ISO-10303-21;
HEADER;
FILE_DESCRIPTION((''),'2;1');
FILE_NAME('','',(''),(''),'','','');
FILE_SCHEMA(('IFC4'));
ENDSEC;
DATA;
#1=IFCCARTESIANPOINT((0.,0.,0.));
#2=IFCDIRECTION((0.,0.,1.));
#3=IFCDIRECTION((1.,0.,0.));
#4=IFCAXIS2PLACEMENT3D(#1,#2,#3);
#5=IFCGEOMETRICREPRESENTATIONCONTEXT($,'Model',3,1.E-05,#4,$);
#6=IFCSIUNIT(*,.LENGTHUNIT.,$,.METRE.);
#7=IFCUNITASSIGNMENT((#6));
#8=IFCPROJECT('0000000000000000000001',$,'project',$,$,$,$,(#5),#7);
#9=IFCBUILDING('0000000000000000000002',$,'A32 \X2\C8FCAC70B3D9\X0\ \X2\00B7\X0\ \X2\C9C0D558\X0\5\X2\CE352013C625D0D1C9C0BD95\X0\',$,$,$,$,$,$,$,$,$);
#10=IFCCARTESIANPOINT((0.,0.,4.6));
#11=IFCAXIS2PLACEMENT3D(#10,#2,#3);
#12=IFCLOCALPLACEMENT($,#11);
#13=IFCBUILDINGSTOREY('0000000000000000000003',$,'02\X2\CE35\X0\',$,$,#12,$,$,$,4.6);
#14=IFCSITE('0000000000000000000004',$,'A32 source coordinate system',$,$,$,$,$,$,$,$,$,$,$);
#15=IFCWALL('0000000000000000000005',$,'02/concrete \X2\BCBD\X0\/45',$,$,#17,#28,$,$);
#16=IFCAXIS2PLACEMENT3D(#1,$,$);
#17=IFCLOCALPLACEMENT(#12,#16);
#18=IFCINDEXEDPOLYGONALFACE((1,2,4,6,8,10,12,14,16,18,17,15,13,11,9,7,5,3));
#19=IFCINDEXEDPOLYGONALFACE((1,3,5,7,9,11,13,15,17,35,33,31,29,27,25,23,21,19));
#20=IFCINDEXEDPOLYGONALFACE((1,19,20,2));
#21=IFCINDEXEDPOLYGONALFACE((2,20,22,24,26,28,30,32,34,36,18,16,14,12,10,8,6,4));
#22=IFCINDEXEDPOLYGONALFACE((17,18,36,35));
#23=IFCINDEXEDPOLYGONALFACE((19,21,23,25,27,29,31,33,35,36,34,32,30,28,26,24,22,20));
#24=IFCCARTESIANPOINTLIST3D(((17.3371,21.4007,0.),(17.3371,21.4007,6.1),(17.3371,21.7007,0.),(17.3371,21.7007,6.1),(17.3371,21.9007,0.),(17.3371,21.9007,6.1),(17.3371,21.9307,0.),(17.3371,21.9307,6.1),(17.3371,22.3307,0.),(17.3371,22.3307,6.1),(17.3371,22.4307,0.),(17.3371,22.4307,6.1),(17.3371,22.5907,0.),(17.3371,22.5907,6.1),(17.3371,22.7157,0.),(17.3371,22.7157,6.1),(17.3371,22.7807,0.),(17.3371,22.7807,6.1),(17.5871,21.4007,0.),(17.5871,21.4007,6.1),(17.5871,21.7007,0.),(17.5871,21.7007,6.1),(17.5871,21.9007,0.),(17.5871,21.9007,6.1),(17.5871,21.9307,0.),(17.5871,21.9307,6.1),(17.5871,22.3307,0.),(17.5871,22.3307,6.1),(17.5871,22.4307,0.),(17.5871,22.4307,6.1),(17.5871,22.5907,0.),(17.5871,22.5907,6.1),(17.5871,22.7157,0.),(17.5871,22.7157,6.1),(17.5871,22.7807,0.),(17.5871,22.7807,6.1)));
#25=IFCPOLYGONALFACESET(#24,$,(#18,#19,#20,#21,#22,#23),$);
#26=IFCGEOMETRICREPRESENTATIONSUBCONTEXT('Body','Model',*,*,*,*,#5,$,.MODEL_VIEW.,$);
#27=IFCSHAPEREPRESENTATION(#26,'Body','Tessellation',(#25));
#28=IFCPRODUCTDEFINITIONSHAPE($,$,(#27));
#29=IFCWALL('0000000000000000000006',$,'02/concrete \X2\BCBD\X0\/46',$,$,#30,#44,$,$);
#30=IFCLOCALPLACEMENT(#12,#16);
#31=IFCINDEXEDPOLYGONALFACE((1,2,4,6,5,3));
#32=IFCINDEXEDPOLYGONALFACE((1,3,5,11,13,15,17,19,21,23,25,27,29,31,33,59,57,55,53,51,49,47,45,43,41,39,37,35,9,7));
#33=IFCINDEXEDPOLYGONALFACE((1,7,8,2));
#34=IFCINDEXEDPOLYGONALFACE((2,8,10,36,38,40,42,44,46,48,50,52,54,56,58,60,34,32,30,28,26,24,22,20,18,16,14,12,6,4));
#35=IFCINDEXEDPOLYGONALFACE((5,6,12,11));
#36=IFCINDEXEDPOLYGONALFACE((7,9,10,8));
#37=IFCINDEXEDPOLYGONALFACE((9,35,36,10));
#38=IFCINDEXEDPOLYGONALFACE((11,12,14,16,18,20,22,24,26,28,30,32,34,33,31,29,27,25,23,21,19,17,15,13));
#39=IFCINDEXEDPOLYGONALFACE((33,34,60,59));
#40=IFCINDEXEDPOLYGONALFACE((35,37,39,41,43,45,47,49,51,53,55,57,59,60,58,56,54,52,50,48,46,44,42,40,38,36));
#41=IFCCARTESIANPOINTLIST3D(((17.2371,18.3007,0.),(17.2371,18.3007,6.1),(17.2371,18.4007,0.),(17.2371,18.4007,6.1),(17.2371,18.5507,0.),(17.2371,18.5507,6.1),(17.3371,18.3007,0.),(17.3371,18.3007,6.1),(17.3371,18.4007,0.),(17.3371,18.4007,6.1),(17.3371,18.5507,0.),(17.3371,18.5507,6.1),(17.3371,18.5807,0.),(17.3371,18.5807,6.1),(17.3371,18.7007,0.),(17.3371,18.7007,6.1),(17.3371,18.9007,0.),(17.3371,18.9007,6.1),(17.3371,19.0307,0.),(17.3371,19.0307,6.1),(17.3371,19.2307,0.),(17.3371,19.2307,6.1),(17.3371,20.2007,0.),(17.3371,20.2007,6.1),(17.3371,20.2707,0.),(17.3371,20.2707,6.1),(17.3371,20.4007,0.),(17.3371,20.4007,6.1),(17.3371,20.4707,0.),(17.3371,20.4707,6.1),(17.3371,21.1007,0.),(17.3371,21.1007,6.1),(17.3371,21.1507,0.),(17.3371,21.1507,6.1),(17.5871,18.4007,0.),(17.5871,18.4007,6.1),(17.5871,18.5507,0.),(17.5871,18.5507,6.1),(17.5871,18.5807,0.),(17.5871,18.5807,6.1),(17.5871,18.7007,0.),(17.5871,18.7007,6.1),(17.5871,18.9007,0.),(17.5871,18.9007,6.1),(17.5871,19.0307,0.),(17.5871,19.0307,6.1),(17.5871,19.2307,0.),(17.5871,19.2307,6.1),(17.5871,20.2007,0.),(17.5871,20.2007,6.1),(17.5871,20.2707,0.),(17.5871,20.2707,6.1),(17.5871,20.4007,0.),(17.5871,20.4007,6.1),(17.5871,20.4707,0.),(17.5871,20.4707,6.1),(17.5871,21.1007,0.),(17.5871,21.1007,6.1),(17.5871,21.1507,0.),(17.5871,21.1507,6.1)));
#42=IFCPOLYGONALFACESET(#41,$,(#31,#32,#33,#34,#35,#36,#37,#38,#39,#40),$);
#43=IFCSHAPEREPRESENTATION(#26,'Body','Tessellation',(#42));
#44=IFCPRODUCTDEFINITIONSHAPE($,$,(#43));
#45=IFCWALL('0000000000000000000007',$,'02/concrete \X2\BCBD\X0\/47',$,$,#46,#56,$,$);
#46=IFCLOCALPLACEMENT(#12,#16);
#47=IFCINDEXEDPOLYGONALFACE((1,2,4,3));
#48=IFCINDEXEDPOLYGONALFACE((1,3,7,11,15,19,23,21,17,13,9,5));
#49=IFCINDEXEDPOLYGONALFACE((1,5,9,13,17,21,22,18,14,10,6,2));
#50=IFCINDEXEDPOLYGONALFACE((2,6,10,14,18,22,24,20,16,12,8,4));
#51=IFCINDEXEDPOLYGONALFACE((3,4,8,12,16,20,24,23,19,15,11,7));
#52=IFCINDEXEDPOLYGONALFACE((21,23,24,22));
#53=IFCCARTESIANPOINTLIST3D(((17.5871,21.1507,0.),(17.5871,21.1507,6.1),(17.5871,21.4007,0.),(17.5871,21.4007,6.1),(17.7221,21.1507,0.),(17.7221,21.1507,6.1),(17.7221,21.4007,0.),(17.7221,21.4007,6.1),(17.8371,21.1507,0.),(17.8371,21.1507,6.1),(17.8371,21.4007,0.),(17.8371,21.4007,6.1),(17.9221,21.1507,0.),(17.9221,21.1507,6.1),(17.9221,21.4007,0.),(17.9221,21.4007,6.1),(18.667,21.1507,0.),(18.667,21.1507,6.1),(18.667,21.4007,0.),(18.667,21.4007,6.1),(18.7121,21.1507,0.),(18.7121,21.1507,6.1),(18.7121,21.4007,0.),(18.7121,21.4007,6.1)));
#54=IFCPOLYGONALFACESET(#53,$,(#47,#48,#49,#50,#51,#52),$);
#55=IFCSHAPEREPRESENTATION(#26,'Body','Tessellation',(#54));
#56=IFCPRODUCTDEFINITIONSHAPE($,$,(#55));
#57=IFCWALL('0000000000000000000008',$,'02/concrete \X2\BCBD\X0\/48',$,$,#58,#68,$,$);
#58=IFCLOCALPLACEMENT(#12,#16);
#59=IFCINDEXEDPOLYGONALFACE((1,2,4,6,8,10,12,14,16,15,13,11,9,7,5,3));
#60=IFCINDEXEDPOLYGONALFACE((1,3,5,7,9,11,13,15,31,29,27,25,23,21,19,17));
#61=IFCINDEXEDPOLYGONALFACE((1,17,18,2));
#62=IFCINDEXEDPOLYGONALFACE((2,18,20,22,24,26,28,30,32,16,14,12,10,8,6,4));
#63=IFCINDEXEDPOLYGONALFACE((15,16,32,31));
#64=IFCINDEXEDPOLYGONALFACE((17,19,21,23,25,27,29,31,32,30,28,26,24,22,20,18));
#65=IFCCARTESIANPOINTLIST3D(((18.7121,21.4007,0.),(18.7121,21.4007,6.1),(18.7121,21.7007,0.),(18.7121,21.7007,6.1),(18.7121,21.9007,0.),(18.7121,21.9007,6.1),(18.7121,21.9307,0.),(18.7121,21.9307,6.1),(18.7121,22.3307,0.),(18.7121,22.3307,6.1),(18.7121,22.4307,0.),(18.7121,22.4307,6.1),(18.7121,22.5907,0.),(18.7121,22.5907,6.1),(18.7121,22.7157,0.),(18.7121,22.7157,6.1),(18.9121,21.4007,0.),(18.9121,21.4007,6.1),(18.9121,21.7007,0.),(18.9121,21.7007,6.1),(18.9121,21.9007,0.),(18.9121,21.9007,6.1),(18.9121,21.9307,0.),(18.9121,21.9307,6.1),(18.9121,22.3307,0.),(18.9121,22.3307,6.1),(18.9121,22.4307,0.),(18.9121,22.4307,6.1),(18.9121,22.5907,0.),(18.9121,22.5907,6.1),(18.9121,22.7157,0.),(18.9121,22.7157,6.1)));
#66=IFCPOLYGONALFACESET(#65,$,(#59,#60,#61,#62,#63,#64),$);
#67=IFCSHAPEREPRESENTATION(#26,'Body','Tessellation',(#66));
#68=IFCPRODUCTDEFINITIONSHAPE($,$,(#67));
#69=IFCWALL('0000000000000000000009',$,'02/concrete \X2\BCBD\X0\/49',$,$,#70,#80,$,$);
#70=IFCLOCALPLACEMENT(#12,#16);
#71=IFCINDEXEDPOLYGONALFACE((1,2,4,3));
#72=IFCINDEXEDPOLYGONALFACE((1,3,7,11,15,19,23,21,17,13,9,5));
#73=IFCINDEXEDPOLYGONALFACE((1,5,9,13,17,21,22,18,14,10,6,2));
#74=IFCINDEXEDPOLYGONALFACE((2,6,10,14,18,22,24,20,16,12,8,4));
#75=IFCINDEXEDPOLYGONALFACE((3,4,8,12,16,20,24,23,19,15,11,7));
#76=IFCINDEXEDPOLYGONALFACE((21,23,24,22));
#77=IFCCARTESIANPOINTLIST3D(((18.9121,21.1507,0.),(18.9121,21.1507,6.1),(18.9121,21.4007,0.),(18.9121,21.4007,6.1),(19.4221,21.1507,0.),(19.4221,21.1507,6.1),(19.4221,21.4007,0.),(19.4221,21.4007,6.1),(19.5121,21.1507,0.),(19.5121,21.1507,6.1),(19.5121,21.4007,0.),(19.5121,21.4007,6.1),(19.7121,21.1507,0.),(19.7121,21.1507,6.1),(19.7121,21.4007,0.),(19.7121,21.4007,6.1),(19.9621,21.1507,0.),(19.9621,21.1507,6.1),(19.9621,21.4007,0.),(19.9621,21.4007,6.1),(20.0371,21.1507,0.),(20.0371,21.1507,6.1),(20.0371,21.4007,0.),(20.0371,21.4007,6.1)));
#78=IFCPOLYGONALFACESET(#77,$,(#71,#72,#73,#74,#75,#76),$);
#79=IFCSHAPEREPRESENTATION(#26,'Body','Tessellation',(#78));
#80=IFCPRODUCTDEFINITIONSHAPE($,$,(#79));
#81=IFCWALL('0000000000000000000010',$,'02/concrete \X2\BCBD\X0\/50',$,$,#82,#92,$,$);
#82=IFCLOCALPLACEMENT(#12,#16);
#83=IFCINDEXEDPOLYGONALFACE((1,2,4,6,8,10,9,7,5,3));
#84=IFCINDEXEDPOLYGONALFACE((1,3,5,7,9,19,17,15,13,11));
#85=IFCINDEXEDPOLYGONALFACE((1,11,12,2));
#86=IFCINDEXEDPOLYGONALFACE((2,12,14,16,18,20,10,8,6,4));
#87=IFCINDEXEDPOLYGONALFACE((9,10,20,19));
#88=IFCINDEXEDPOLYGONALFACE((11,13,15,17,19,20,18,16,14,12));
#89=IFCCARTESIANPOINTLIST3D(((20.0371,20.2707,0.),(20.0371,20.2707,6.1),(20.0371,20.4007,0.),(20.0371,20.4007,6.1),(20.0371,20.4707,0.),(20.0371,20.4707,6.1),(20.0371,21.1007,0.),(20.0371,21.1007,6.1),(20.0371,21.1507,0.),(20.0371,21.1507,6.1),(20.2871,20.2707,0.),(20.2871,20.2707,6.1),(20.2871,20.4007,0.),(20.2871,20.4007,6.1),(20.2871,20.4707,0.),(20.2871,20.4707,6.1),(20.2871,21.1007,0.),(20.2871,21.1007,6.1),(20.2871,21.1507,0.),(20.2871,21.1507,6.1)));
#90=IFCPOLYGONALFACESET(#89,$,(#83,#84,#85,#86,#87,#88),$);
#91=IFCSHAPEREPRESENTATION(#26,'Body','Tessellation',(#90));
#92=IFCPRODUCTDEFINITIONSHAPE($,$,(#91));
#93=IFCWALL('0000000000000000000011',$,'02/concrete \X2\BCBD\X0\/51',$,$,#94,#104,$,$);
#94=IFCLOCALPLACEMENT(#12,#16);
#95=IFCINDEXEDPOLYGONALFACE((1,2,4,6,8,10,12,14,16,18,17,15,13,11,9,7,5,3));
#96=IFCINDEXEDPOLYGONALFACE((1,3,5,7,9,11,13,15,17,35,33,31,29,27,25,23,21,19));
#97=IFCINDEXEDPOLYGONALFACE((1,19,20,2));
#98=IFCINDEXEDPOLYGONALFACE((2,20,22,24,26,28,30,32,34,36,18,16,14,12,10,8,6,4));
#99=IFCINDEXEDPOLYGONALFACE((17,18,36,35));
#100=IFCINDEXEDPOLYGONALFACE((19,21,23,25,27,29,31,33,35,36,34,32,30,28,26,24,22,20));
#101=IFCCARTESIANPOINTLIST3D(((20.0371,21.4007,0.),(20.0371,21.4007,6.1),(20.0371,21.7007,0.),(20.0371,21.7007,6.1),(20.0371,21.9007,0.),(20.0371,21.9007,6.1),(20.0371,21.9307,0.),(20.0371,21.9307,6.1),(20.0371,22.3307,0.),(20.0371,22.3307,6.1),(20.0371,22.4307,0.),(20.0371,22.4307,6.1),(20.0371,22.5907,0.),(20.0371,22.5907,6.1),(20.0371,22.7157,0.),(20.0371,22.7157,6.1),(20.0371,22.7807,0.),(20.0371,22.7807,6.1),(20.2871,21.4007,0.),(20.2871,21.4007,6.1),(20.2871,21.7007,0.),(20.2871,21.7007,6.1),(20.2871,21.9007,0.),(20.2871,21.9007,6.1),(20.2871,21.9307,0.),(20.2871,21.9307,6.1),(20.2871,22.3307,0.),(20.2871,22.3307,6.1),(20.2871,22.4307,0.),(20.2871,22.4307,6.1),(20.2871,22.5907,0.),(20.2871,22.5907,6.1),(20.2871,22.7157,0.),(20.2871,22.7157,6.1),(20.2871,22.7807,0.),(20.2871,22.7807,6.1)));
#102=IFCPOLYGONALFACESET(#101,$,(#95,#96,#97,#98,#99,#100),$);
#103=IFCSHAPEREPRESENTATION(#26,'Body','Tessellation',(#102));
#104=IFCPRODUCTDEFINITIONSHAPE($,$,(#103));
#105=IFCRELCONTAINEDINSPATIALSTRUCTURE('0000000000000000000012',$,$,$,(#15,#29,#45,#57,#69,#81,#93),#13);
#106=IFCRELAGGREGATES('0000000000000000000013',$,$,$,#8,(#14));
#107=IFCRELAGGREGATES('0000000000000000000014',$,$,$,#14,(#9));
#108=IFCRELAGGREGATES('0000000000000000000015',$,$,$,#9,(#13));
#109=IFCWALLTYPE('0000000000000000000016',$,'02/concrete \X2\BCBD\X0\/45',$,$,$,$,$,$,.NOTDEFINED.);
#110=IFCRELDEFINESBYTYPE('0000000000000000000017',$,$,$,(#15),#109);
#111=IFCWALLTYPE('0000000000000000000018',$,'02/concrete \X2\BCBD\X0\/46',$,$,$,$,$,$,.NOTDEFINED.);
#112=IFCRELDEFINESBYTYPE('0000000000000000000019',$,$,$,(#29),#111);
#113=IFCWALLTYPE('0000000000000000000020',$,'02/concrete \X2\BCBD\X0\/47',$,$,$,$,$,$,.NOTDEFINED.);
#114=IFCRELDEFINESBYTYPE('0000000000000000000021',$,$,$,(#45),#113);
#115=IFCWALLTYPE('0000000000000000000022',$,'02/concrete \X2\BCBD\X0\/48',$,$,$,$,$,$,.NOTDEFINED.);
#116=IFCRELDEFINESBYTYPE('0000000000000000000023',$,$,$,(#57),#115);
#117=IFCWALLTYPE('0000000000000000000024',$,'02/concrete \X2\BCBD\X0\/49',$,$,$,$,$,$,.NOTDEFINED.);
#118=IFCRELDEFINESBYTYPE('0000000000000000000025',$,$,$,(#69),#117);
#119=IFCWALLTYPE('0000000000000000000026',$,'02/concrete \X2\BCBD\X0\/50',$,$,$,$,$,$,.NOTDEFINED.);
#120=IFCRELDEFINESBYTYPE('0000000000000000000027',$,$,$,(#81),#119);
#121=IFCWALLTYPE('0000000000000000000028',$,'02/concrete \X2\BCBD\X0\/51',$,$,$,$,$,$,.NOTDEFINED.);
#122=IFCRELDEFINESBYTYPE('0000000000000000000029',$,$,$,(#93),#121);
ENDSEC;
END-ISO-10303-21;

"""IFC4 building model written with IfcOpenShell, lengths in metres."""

from ifc_helpers import new_model, si_unit, frame, origin, origin_with_axes, place, context, subcontext, project, spatial, polyline, outline, extrude, source, transform, mapped, type_object, type_shapes, element, save


model = new_model("IFC4")

# Units and contexts
model_context = context("Model", 3, precision=1e-05, world=origin_with_axes())
body_context = subcontext(model_context, "Body", "Model", "MODEL_VIEW")
ifc_project = project(units=[si_unit("LENGTHUNIT", "METRE")], contexts=[model_context])

# Site, building, storey
site = spatial("IfcSite", under=ifc_project, Name="A32 source coordinate system")
building = spatial("IfcBuilding", under=site, Name="A32 주거동 · 지하5층–옥탑지붕")
storey_placement = place(None, frame((0.0, 0.0, 4.6), z_axis=(0.0, 0.0, 1.0), x_axis=(1.0, 0.0, 0.0)))
storey = spatial("IfcBuildingStorey", under=building, at=storey_placement, Name="02층", Elevation=4.6)

# Walls
wall_type_1 = type_object("IfcWallType", Name="02/concrete 벽/45", PredefinedType="NOTDEFINED")
shared_shape_1 = source(origin(), body_context, "Body", "SweptSolid", [
    extrude(outline(polyline([(17.3371, 21.9307), (17.3371, 22.3307), (17.3371, 22.4307), (17.3371, 22.5907), (17.3371, 22.7157), (17.3371, 22.7807), (17.5871, 22.7807), (17.5871, 22.7157), (17.5871, 22.5907), (17.5871, 22.4307), (17.5871, 22.3307), (17.5871, 21.9307), (17.5871, 21.9007), (17.5871, 21.7007), (17.5871, 21.4007), (17.3371, 21.4007), (17.3371, 21.7007), (17.3371, 21.9007), (17.3371, 21.9307)])), origin(), (0.0, 0.0, 1.0), 6.1),
])
type_shapes(wall_type_1, [shared_shape_1])
wall_1_placement = place(storey_placement, origin_with_axes())
element("IfcWall", 1, at=wall_1_placement, inside=storey, type_object=wall_type_1, Name="02/concrete 벽/45", context=body_context, shape_type="MappedRepresentation", body=[
    mapped(shared_shape_1, transform((0.0, 0.0, 0.0), scale=1.0)),
])
wall_type_2 = type_object("IfcWallType", Name="02/concrete 벽/46", PredefinedType="NOTDEFINED")
shared_shape_2 = source(origin(), body_context, "Body", "SweptSolid", [
    extrude(outline(polyline([(17.5871, 20.4707), (17.5871, 20.4007), (17.5871, 20.2707), (17.5871, 20.2007), (17.5871, 19.2307), (17.5871, 19.0307), (17.5871, 18.9007), (17.5871, 18.7007), (17.5871, 18.5807), (17.5871, 18.5507), (17.5871, 18.4007), (17.3371, 18.4007), (17.3371, 18.3007), (17.2371, 18.3007), (17.2371, 18.4007), (17.2371, 18.5507), (17.3371, 18.5507), (17.3371, 18.5807), (17.3371, 18.7007), (17.3371, 18.9007), (17.3371, 19.0307), (17.3371, 19.2307), (17.3371, 20.2007), (17.3371, 20.2707), (17.3371, 20.4007), (17.3371, 20.4707), (17.3371, 21.1007), (17.3371, 21.1507), (17.5871, 21.1507), (17.5871, 21.1007), (17.5871, 20.4707)])), origin(), (0.0, 0.0, 1.0), 6.1),
])
type_shapes(wall_type_2, [shared_shape_2])
wall_2_placement = place(storey_placement, origin_with_axes())
element("IfcWall", 2, at=wall_2_placement, inside=storey, type_object=wall_type_2, Name="02/concrete 벽/46", context=body_context, shape_type="MappedRepresentation", body=[
    mapped(shared_shape_2, transform((0.0, 0.0, 0.0), scale=1.0)),
])
wall_type_3 = type_object("IfcWallType", Name="02/concrete 벽/47", PredefinedType="NOTDEFINED")
shared_shape_3 = source(origin(), body_context, "Body", "SweptSolid", [
    extrude(outline(polyline([(17.8371, 21.4007), (17.9221, 21.4007), (18.667, 21.4007), (18.7121, 21.4007), (18.7121, 21.1507), (18.667, 21.1507), (17.9221, 21.1507), (17.8371, 21.1507), (17.7221, 21.1507), (17.5871, 21.1507), (17.5871, 21.4007), (17.7221, 21.4007), (17.8371, 21.4007)])), origin(), (0.0, 0.0, 1.0), 6.1),
])
type_shapes(wall_type_3, [shared_shape_3])
wall_3_placement = place(storey_placement, origin_with_axes())
element("IfcWall", 3, at=wall_3_placement, inside=storey, type_object=wall_type_3, Name="02/concrete 벽/47", context=body_context, shape_type="MappedRepresentation", body=[
    mapped(shared_shape_3, transform((0.0, 0.0, 0.0), scale=1.0)),
])
wall_type_4 = type_object("IfcWallType", Name="02/concrete 벽/48", PredefinedType="NOTDEFINED")
shared_shape_4 = source(origin(), body_context, "Body", "SweptSolid", [
    extrude(outline(polyline([(18.7121, 21.9307), (18.7121, 22.3307), (18.7121, 22.4307), (18.7121, 22.5907), (18.7121, 22.7157), (18.9121, 22.7157), (18.9121, 22.5907), (18.9121, 22.4307), (18.9121, 22.3307), (18.9121, 21.9307), (18.9121, 21.9007), (18.9121, 21.7007), (18.9121, 21.4007), (18.7121, 21.4007), (18.7121, 21.7007), (18.7121, 21.9007), (18.7121, 21.9307)])), origin(), (0.0, 0.0, 1.0), 6.1),
])
type_shapes(wall_type_4, [shared_shape_4])
wall_4_placement = place(storey_placement, origin_with_axes())
element("IfcWall", 4, at=wall_4_placement, inside=storey, type_object=wall_type_4, Name="02/concrete 벽/48", context=body_context, shape_type="MappedRepresentation", body=[
    mapped(shared_shape_4, transform((0.0, 0.0, 0.0), scale=1.0)),
])
wall_type_5 = type_object("IfcWallType", Name="02/concrete 벽/49", PredefinedType="NOTDEFINED")
shared_shape_5 = source(origin(), body_context, "Body", "SweptSolid", [
    extrude(outline(polyline([(19.7121, 21.4007), (19.9621, 21.4007), (20.0371, 21.4007), (20.0371, 21.1507), (19.9621, 21.1507), (19.7121, 21.1507), (19.5121, 21.1507), (19.4221, 21.1507), (18.9121, 21.1507), (18.9121, 21.4007), (19.4221, 21.4007), (19.5121, 21.4007), (19.7121, 21.4007)])), origin(), (0.0, 0.0, 1.0), 6.1),
])
type_shapes(wall_type_5, [shared_shape_5])
wall_5_placement = place(storey_placement, origin_with_axes())
element("IfcWall", 5, at=wall_5_placement, inside=storey, type_object=wall_type_5, Name="02/concrete 벽/49", context=body_context, shape_type="MappedRepresentation", body=[
    mapped(shared_shape_5, transform((0.0, 0.0, 0.0), scale=1.0)),
])
wall_type_6 = type_object("IfcWallType", Name="02/concrete 벽/50", PredefinedType="NOTDEFINED")
shared_shape_6 = source(origin(), body_context, "Body", "SweptSolid", [
    extrude(outline(polyline([(20.2871, 20.4707), (20.2871, 20.4007), (20.2871, 20.2707), (20.0371, 20.2707), (20.0371, 20.4007), (20.0371, 20.4707), (20.0371, 21.1007), (20.0371, 21.1507), (20.2871, 21.1507), (20.2871, 21.1007), (20.2871, 20.4707)])), origin(), (0.0, 0.0, 1.0), 6.1),
])
type_shapes(wall_type_6, [shared_shape_6])
wall_6_placement = place(storey_placement, origin_with_axes())
element("IfcWall", 6, at=wall_6_placement, inside=storey, type_object=wall_type_6, Name="02/concrete 벽/50", context=body_context, shape_type="MappedRepresentation", body=[
    mapped(shared_shape_6, transform((0.0, 0.0, 0.0), scale=1.0)),
])
wall_type_7 = type_object("IfcWallType", Name="02/concrete 벽/51", PredefinedType="NOTDEFINED")
shared_shape_7 = source(origin(), body_context, "Body", "SweptSolid", [
    extrude(outline(polyline([(20.0371, 21.9307), (20.0371, 22.3307), (20.0371, 22.4307), (20.0371, 22.5907), (20.0371, 22.7157), (20.0371, 22.7807), (20.2871, 22.7807), (20.2871, 22.7157), (20.2871, 22.5907), (20.2871, 22.4307), (20.2871, 22.3307), (20.2871, 21.9307), (20.2871, 21.9007), (20.2871, 21.7007), (20.2871, 21.4007), (20.0371, 21.4007), (20.0371, 21.7007), (20.0371, 21.9007), (20.0371, 21.9307)])), origin(), (0.0, 0.0, 1.0), 6.1),
])
type_shapes(wall_type_7, [shared_shape_7])
wall_7_placement = place(storey_placement, origin_with_axes())
element("IfcWall", 7, at=wall_7_placement, inside=storey, type_object=wall_type_7, Name="02/concrete 벽/51", context=body_context, shape_type="MappedRepresentation", body=[
    mapped(shared_shape_7, transform((0.0, 0.0, 0.0), scale=1.0)),
])

save(model, "model.ifc")
